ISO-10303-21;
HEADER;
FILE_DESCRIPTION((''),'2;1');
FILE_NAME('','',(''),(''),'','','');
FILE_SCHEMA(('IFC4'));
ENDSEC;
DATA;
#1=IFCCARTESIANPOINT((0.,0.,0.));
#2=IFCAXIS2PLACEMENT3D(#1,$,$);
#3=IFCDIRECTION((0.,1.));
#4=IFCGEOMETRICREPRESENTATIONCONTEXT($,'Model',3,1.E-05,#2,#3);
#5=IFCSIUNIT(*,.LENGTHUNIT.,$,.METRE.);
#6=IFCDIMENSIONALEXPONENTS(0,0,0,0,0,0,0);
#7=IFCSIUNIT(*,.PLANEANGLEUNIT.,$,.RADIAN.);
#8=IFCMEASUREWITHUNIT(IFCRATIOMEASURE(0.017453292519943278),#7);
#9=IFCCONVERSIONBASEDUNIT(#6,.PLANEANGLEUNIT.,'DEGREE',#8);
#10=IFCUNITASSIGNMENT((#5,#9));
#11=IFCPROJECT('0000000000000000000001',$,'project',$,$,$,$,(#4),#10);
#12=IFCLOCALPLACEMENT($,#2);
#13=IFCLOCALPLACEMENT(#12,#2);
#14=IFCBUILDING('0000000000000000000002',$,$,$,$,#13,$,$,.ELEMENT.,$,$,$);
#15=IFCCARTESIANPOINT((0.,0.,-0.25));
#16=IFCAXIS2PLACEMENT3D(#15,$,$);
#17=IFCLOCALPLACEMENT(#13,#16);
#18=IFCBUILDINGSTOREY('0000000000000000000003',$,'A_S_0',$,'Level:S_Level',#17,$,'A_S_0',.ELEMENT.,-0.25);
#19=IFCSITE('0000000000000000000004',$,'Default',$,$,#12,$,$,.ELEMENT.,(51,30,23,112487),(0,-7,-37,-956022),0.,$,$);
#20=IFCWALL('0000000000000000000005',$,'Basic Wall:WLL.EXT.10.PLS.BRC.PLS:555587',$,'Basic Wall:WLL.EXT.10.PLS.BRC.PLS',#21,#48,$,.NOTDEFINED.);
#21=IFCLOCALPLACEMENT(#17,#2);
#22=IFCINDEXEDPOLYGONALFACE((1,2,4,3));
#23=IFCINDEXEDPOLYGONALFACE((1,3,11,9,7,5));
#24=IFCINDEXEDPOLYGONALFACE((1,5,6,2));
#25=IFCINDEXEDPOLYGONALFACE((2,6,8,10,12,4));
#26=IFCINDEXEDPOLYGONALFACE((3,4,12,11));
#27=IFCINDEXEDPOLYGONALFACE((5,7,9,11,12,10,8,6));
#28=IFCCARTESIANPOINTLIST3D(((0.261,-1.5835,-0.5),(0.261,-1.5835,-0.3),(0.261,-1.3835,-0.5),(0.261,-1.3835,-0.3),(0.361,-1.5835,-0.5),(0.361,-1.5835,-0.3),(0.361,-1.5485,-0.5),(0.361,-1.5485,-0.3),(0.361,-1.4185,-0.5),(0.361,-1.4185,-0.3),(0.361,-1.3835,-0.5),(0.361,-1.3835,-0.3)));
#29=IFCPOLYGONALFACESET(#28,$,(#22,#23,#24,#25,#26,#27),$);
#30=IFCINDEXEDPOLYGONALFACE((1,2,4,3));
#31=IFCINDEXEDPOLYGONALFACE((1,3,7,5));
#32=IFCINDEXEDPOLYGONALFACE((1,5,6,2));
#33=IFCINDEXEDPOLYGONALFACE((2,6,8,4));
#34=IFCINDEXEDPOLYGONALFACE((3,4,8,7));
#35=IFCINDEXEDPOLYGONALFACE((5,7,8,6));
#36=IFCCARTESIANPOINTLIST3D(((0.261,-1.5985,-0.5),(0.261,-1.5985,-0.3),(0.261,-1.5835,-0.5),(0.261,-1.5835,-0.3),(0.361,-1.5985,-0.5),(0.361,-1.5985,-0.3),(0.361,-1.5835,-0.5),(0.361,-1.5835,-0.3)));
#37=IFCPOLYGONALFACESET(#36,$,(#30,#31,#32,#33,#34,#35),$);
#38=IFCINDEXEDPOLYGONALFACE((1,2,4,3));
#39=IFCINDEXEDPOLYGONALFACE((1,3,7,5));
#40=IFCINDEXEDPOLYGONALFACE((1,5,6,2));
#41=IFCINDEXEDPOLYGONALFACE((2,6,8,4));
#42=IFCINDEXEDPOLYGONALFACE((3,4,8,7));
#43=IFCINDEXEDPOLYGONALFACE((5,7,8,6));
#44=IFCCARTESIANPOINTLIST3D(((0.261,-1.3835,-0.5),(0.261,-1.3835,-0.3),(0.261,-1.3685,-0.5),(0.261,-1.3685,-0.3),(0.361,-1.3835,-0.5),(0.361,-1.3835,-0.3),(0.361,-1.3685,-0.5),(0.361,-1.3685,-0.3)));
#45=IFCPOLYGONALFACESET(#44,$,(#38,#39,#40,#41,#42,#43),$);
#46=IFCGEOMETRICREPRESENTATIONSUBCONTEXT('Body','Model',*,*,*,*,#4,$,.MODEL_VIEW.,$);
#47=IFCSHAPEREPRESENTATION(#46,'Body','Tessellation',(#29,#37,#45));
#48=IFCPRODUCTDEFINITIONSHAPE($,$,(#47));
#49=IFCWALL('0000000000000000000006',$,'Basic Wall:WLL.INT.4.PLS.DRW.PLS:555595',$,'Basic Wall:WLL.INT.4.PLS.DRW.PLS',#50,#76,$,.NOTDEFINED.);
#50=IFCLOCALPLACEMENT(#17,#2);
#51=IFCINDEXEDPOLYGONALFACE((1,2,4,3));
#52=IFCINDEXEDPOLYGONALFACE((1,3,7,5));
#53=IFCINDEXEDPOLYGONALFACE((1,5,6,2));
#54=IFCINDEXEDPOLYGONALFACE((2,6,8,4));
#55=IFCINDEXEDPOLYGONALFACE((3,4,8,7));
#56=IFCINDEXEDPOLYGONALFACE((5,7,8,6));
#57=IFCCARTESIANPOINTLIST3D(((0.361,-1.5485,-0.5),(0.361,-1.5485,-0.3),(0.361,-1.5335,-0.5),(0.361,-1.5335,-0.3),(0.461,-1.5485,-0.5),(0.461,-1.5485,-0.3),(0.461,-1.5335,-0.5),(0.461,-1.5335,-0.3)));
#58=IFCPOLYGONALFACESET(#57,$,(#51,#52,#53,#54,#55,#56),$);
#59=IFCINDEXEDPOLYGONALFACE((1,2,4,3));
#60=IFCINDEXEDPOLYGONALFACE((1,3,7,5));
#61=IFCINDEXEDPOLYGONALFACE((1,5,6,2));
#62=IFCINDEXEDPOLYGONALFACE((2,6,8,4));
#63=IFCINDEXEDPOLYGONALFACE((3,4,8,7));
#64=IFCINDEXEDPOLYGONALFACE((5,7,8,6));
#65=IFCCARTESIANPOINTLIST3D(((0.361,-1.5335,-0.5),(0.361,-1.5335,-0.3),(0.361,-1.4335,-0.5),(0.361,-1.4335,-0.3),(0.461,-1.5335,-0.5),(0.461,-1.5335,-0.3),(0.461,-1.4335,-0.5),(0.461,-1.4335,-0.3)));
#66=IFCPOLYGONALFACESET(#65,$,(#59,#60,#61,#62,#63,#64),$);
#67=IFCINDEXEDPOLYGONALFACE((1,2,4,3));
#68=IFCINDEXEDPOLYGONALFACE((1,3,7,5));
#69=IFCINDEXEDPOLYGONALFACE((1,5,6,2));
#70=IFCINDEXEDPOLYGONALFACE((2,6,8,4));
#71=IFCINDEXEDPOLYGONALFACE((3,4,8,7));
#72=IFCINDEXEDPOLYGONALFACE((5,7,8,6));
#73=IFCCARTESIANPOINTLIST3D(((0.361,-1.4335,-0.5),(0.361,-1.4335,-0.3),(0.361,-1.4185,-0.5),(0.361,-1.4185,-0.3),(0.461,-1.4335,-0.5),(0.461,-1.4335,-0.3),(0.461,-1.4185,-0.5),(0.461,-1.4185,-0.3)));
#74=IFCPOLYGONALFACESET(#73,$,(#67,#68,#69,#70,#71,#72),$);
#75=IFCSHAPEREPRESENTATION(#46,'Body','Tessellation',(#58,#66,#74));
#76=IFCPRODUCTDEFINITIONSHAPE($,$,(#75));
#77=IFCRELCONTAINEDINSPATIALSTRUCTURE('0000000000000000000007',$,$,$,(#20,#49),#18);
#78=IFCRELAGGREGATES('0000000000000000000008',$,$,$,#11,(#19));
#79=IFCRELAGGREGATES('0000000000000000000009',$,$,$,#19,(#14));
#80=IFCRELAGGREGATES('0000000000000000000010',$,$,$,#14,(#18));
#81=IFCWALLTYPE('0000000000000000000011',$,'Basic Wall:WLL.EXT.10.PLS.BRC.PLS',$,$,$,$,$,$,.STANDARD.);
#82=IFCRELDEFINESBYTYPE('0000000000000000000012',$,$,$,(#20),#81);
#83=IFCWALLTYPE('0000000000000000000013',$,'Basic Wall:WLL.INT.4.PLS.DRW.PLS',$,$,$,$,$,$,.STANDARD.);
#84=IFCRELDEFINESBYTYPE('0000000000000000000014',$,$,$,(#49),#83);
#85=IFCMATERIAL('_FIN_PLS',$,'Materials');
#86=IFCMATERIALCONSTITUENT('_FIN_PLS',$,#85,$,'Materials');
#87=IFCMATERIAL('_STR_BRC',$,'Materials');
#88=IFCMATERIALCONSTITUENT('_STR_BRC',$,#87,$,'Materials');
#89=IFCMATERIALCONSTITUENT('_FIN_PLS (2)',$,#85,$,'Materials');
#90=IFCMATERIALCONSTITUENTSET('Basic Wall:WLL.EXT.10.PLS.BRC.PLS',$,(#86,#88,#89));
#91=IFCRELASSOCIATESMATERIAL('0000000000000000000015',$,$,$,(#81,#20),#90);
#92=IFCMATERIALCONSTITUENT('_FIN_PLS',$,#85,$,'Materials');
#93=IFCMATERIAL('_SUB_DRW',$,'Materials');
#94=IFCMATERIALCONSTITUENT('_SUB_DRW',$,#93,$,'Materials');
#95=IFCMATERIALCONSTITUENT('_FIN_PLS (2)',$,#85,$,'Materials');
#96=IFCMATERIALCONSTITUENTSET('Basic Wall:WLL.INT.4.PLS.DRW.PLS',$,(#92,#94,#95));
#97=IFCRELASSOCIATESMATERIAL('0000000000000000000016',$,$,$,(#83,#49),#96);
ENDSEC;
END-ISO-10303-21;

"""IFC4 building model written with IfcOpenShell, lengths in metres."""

from ifc_helpers import new_model, entity, si_unit, converted_unit, direction, frame, origin, place, context, subcontext, project, spatial, indexed_curve, outline, extrude, material, constituent, constituent_set, type_object, element, save


model = new_model("IFC4")

# Units and contexts
model_context = context("Model", 3, precision=1e-05, world=origin(), true_north=direction((0.0, 1.0)))
body_context = subcontext(model_context, "Body", "Model", "MODEL_VIEW")
ifc_project = project(units=[si_unit("LENGTHUNIT", "METRE"), converted_unit("PLANEANGLEUNIT", "DEGREE", entity("IfcRatioMeasure", 0.017453292519943278), si_unit("PLANEANGLEUNIT", "RADIAN"), dimensions=[0, 0, 0, 0, 0, 0, 0])], contexts=[model_context])

# Site, building, storey
site_placement = place(None, origin())
site = spatial("IfcSite", under=ifc_project, at=site_placement, Name="Default", CompositionType="ELEMENT", RefLatitude=(51, 30, 23, 112487), RefLongitude=(0, -7, -37, -956022), RefElevation=0.0)
building_placement = place(site_placement, origin())
building = spatial("IfcBuilding", under=site, at=building_placement, CompositionType="ELEMENT")
storey_placement = place(building_placement, frame((0.0, 0.0, -0.25)))
storey = spatial("IfcBuildingStorey", under=building, at=storey_placement, Name="A_S_0", ObjectType="Level:S_Level", LongName="A_S_0", CompositionType="ELEMENT", Elevation=-0.25)

# Walls
ifc_material_1 = material(Name="_FIN_PLS", Category="Materials")
ifc_constituent_1 = constituent(ifc_material_1, Name="_FIN_PLS", Category="Materials")
ifc_material_2 = material(Name="_STR_BRC", Category="Materials")
ifc_constituent_2 = constituent(ifc_material_2, Name="_STR_BRC", Category="Materials")
ifc_constituent_3 = constituent(ifc_material_1, Name="_FIN_PLS (2)", Category="Materials")
ifc_constituent_set_1 = constituent_set(constituents=[ifc_constituent_1, ifc_constituent_2, ifc_constituent_3], Name="Basic Wall:WLL.EXT.10.PLS.BRC.PLS")
wall_type_1 = type_object("IfcWallType", Name="Basic Wall:WLL.EXT.10.PLS.BRC.PLS", PredefinedType="STANDARD", material=ifc_constituent_set_1)
wall_1_placement = place(storey_placement, frame((0.261, -1.4835, -0.5)))
element("IfcWall", 1, at=wall_1_placement, inside=storey, type_object=wall_type_1, material=ifc_constituent_set_1, Name="Basic Wall:WLL.EXT.10.PLS.BRC.PLS:555587", ObjectType="Basic Wall:WLL.EXT.10.PLS.BRC.PLS", PredefinedType="NOTDEFINED", context=body_context, shape_type="SweptSolid", body=[
    extrude(outline(indexed_curve([(0.065, -0.0333), (0.1, -0.0333), (0.1, 0.0667), (-0.1, 0.0667), (-0.1, -0.0333), (-0.065, -0.0333), (0.065, -0.0333)], self_intersect=False)), frame((0.0667, 0.0, 0.0), z_axis=(0.0, 0.0, 1.0), x_axis=(0.0, 1.0, 0.0)), (0.0, 0.0, 1.0), 0.2),
    extrude(outline(indexed_curve([(-0.0075, -0.05), (0.0075, -0.05), (0.0075, 0.05), (-0.0075, 0.05), (-0.0075, -0.05)], self_intersect=False)), frame((0.05, -0.1075, 0.0), z_axis=(0.0, 0.0, 1.0), x_axis=(0.0, 1.0, 0.0)), (0.0, 0.0, 1.0), 0.2),
    extrude(outline(indexed_curve([(-0.0075, -0.05), (0.0075, -0.05), (0.0075, 0.05), (-0.0075, 0.05), (-0.0075, -0.05)], self_intersect=False)), frame((0.05, 0.1075, 0.0), z_axis=(0.0, 0.0, 1.0), x_axis=(0.0, -1.0, 0.0)), (0.0, 0.0, 1.0), 0.2),
])
ifc_constituent_4 = constituent(ifc_material_1, Name="_FIN_PLS", Category="Materials")
ifc_material_3 = material(Name="_SUB_DRW", Category="Materials")
ifc_constituent_5 = constituent(ifc_material_3, Name="_SUB_DRW", Category="Materials")
ifc_constituent_6 = constituent(ifc_material_1, Name="_FIN_PLS (2)", Category="Materials")
ifc_constituent_set_2 = constituent_set(constituents=[ifc_constituent_4, ifc_constituent_5, ifc_constituent_6], Name="Basic Wall:WLL.INT.4.PLS.DRW.PLS")
wall_type_2 = type_object("IfcWallType", Name="Basic Wall:WLL.INT.4.PLS.DRW.PLS", PredefinedType="STANDARD", material=ifc_constituent_set_2)
wall_2_placement = place(storey_placement, frame((0.361, -1.4835, -0.5)))
element("IfcWall", 2, at=wall_2_placement, inside=storey, type_object=wall_type_2, material=ifc_constituent_set_2, Name="Basic Wall:WLL.INT.4.PLS.DRW.PLS:555595", ObjectType="Basic Wall:WLL.INT.4.PLS.DRW.PLS", PredefinedType="NOTDEFINED", context=body_context, shape_type="SweptSolid", body=[
    extrude(outline(indexed_curve([(-0.0075, -0.05), (0.0075, -0.05), (0.0075, 0.05), (-0.0075, 0.05), (-0.0075, -0.05)], self_intersect=False)), frame((0.05, -0.0575, 0.0), z_axis=(0.0, 0.0, 1.0), x_axis=(0.0, 1.0, 0.0)), (0.0, 0.0, 1.0), 0.2),
    extrude(outline(indexed_curve([(-0.05, -0.05), (0.05, -0.05), (0.05, 0.05), (-0.05, 0.05), (-0.05, -0.05)], self_intersect=False)), frame((0.05, 0.0, 0.0)), (0.0, 0.0, 1.0), 0.2),
    extrude(outline(indexed_curve([(-0.0075, -0.05), (0.0075, -0.05), (0.0075, 0.05), (-0.0075, 0.05), (-0.0075, -0.05)], self_intersect=False)), frame((0.05, 0.0575, 0.0), z_axis=(0.0, 0.0, 1.0), x_axis=(0.0, -1.0, 0.0)), (0.0, 0.0, 1.0), 0.2),
])

save(model, "model.ifc")
